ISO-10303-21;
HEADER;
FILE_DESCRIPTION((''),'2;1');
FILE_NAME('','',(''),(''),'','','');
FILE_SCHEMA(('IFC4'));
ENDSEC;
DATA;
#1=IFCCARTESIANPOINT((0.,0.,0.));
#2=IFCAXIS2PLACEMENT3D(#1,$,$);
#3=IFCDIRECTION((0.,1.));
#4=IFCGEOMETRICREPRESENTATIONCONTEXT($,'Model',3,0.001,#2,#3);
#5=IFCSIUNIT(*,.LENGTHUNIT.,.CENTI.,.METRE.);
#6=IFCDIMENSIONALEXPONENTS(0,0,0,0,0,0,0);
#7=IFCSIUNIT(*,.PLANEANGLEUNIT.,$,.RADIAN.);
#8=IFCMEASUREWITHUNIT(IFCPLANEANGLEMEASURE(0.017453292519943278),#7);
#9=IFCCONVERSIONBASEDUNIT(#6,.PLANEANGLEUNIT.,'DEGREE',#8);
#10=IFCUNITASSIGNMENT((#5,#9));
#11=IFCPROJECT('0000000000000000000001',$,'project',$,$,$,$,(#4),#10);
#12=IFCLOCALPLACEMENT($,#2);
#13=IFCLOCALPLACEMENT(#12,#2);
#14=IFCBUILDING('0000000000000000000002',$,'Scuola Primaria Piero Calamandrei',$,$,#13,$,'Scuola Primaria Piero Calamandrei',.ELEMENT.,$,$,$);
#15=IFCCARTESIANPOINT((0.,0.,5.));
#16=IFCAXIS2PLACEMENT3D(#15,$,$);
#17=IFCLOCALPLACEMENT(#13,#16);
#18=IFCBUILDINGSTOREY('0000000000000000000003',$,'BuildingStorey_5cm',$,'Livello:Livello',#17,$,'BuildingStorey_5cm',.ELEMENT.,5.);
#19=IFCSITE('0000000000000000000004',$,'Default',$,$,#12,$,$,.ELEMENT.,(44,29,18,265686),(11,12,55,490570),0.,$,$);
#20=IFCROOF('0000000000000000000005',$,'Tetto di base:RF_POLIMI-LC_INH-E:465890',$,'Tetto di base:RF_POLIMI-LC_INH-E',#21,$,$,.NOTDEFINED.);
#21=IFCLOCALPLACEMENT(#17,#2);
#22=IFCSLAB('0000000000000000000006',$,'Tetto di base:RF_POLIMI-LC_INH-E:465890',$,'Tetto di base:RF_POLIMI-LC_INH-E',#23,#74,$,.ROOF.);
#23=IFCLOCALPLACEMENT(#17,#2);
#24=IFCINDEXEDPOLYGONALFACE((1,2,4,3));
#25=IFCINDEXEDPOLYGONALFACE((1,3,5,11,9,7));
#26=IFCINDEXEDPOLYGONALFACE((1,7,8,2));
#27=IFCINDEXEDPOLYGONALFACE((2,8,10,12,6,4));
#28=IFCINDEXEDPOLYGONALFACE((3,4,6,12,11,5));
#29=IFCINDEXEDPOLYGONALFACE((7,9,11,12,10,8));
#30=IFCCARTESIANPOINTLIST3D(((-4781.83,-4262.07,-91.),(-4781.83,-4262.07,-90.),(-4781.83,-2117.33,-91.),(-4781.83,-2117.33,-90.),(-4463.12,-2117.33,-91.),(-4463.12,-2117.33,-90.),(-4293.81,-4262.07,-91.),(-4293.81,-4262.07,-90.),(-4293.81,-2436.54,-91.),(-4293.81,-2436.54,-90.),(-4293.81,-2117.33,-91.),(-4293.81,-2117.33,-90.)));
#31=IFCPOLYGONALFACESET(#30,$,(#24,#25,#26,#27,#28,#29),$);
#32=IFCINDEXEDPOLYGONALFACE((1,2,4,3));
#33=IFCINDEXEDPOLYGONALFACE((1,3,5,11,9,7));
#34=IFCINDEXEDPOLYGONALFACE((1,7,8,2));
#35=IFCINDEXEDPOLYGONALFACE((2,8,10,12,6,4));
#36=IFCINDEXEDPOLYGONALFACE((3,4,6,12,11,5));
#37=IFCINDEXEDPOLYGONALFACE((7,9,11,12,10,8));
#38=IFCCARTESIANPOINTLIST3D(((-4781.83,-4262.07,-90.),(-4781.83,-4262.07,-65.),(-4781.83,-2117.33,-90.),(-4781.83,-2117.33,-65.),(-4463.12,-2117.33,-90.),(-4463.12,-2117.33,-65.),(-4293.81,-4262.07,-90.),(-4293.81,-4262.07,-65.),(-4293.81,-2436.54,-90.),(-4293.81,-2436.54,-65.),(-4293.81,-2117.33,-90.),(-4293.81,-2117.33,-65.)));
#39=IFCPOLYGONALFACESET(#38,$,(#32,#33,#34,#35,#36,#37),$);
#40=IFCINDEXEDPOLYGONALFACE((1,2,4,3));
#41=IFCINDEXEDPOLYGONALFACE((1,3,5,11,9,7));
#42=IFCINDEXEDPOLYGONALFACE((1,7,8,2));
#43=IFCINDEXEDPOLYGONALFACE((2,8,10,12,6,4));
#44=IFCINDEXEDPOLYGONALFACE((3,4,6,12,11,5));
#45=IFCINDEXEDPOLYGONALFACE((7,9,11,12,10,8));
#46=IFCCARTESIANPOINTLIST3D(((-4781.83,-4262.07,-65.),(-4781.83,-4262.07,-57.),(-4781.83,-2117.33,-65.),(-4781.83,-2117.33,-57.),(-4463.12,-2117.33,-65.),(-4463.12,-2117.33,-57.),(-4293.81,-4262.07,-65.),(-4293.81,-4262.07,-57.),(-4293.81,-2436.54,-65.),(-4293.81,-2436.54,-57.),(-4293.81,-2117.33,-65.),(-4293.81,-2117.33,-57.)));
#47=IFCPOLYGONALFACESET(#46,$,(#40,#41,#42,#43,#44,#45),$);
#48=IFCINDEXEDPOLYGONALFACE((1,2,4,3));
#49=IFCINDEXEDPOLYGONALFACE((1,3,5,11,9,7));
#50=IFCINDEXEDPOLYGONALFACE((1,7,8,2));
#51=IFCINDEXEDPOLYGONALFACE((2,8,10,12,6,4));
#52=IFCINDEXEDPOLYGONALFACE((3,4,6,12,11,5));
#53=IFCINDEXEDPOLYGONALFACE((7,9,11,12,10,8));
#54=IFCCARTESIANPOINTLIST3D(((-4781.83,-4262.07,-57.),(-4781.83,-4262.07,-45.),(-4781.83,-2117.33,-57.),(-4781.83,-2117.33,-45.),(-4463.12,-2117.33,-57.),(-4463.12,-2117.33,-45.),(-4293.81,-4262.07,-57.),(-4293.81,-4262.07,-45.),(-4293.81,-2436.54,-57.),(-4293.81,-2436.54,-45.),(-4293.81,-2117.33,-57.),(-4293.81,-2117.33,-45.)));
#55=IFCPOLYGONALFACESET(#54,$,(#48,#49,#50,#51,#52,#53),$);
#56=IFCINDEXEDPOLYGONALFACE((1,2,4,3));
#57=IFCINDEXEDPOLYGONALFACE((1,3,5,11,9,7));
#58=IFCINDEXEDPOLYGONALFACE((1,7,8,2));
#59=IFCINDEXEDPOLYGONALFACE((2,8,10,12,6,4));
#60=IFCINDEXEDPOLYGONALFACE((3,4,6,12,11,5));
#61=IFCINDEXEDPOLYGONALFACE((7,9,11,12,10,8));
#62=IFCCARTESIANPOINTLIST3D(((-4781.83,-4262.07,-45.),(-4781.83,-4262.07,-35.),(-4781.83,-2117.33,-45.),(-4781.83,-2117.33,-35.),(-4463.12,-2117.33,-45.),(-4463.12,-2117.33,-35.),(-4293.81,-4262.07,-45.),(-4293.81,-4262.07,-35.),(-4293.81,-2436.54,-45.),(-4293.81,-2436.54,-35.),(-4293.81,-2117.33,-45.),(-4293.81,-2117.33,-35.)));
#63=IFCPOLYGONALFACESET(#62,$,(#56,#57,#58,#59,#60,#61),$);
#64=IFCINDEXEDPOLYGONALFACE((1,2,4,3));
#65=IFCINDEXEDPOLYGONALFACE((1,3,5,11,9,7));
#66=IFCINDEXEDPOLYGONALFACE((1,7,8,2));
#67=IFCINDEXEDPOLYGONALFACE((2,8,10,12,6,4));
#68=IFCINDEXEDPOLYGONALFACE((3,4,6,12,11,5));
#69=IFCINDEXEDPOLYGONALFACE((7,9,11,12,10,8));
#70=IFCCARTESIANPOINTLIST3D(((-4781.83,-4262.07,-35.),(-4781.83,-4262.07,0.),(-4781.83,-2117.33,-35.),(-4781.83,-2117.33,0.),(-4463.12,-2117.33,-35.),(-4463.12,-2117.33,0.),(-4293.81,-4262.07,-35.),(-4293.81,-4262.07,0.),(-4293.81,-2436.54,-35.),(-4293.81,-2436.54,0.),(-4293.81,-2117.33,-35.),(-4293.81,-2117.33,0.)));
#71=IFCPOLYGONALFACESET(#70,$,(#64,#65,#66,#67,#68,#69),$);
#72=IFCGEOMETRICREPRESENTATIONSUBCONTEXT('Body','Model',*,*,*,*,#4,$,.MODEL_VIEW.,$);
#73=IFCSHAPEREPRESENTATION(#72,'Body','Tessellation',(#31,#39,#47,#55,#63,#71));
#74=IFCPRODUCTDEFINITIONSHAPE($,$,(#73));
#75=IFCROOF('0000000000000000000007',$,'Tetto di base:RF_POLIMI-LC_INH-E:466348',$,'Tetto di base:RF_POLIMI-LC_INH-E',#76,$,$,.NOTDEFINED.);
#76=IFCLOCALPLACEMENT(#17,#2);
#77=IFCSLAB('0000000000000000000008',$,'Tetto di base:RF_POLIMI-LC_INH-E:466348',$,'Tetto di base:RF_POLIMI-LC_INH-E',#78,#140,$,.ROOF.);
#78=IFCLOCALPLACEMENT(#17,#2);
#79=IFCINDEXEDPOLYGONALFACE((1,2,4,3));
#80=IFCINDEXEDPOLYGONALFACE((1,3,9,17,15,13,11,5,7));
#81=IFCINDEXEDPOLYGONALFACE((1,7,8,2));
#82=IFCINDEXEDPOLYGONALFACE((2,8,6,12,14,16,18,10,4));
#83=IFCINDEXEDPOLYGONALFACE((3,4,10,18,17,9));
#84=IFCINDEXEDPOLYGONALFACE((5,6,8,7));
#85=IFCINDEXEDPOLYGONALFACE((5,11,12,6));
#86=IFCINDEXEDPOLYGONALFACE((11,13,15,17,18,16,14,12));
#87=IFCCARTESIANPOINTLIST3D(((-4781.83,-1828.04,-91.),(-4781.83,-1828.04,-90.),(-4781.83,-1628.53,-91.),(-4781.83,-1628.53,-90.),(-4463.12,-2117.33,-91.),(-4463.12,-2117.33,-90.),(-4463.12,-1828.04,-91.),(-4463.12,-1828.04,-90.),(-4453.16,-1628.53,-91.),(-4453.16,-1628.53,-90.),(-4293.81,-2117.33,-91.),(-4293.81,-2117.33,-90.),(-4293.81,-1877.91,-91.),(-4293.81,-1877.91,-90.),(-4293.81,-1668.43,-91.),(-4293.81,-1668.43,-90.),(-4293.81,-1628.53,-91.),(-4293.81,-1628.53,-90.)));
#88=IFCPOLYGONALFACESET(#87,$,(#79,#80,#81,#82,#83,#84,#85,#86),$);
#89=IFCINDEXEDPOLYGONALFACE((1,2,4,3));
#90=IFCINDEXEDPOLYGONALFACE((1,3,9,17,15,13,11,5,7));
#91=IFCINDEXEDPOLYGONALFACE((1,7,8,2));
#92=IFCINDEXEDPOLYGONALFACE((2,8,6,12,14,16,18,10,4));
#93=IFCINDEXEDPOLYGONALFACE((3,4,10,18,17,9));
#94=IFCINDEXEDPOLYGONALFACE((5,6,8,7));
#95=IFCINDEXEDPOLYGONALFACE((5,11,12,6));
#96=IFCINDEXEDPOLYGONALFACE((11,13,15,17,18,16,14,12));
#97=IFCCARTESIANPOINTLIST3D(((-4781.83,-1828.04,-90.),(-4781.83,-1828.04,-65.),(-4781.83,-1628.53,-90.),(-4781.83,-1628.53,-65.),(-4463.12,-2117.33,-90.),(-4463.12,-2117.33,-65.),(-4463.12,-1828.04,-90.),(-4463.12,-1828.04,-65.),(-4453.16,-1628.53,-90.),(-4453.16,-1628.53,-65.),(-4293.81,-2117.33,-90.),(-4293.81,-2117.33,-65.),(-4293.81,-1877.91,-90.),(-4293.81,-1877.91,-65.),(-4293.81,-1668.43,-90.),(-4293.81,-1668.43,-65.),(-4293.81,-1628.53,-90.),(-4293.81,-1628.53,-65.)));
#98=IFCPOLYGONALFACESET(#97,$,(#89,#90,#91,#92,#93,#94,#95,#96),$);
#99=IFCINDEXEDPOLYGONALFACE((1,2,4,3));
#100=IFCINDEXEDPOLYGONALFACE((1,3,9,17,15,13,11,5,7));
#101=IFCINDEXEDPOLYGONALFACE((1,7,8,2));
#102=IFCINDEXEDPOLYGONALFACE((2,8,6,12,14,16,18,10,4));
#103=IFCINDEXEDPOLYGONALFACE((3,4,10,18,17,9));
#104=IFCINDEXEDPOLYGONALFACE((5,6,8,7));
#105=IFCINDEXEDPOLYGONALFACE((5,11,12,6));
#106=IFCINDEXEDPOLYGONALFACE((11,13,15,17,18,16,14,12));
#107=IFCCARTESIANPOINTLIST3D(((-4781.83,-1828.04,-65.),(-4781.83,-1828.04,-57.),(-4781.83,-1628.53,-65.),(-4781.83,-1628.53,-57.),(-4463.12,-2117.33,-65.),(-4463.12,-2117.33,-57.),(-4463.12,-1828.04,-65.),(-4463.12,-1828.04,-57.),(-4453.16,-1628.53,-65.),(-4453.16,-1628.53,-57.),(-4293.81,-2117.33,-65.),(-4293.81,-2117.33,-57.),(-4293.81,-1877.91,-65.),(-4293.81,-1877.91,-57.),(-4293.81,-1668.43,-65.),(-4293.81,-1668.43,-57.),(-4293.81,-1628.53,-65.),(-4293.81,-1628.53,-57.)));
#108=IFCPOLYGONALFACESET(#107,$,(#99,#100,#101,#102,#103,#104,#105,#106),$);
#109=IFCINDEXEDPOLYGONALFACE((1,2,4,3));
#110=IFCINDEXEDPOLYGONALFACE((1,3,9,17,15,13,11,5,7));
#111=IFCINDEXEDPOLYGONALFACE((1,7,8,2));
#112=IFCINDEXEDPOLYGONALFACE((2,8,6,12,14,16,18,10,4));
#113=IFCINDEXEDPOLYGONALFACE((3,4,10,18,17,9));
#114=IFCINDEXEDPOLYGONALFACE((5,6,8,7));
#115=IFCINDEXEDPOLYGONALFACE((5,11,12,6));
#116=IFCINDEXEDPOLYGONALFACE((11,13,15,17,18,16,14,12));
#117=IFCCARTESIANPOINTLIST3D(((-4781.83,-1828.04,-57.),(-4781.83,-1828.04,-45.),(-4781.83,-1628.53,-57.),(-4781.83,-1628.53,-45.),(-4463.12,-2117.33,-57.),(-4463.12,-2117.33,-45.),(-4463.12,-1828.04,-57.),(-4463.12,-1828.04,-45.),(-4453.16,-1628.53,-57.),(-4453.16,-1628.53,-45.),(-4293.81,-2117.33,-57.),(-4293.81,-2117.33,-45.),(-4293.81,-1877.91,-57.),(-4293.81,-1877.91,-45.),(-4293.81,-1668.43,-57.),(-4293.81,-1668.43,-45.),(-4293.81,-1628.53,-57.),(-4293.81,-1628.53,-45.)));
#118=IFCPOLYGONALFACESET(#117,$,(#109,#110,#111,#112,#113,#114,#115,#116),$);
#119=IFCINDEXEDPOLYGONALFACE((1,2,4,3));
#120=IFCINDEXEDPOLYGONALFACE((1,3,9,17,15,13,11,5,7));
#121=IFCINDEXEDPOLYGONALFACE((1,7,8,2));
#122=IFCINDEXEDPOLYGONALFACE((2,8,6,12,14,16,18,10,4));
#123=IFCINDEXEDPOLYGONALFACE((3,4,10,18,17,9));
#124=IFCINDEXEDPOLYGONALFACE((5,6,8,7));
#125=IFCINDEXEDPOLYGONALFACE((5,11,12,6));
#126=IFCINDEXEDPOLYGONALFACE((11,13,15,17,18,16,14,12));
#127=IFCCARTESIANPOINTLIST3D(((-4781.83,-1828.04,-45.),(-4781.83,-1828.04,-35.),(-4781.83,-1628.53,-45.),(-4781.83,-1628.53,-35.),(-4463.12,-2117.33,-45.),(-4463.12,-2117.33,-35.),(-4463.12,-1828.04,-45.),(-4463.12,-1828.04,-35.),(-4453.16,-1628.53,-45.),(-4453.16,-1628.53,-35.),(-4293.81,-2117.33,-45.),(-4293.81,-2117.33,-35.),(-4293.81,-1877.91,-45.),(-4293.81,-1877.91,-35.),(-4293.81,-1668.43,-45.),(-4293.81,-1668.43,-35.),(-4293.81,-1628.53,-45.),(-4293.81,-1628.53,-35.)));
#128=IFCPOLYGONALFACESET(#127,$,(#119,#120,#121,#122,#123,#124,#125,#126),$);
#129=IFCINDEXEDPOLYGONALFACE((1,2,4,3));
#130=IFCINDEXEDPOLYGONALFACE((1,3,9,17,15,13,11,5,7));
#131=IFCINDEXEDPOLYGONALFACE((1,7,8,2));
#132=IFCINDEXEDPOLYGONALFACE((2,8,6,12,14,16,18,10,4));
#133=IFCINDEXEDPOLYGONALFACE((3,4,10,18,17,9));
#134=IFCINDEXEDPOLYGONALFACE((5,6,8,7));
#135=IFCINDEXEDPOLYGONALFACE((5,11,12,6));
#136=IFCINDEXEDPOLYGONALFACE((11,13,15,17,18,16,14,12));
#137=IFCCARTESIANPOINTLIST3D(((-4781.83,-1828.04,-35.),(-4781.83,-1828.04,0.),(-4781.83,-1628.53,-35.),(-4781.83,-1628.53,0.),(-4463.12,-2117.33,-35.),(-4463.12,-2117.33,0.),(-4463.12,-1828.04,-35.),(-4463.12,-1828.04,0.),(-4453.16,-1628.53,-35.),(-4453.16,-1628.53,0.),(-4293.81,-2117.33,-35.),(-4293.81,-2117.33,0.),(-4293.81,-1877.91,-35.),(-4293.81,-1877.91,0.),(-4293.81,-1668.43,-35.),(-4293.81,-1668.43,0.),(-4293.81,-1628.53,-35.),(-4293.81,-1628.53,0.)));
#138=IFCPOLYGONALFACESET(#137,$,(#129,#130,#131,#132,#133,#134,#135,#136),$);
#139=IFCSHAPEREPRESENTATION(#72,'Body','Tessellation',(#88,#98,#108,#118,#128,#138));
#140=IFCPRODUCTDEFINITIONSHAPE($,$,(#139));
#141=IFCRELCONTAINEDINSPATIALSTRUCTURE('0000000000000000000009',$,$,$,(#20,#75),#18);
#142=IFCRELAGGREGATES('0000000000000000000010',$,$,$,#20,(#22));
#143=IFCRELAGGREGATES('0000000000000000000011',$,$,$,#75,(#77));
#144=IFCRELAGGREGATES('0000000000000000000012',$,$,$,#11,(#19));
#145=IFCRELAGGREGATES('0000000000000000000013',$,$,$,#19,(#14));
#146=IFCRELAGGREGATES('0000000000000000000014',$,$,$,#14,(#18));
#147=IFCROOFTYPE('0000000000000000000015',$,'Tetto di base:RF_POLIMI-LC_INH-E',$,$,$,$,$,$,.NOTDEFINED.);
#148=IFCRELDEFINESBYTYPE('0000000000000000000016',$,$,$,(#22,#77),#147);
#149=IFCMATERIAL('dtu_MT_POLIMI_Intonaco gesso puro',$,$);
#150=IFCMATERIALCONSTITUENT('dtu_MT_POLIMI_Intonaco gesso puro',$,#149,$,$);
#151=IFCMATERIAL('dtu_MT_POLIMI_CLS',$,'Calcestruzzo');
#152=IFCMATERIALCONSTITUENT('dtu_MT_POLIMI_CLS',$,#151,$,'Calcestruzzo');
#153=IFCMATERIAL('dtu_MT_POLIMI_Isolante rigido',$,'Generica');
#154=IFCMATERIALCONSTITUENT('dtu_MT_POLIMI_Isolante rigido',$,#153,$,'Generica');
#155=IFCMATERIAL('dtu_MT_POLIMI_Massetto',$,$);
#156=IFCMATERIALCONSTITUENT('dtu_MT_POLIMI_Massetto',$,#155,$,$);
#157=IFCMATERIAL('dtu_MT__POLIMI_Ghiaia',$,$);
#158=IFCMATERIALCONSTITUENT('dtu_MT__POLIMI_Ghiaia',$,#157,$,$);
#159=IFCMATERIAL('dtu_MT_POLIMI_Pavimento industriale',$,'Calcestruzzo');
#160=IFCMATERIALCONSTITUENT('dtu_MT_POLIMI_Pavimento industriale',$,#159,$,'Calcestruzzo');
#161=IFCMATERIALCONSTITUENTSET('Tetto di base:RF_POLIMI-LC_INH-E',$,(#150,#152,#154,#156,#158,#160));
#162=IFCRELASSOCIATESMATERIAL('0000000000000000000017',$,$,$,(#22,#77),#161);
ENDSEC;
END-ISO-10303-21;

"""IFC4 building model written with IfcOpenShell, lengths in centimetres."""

from ifc_helpers import new_model, entity, si_unit, converted_unit, direction, frame, origin, place, context, subcontext, project, spatial, indexed_curve, outline, extrude, material, constituent, constituent_set, type_object, element, aggregate, save


model = new_model("IFC4")

# Units and contexts
model_context = context("Model", 3, precision=0.001, world=origin(), true_north=direction((0.0, 1.0)))
body_context = subcontext(model_context, "Body", "Model", "MODEL_VIEW")
ifc_project = project(units=[si_unit("LENGTHUNIT", "METRE", prefix="CENTI"), converted_unit("PLANEANGLEUNIT", "DEGREE", entity("IfcPlaneAngleMeasure", 0.017453292519943278), si_unit("PLANEANGLEUNIT", "RADIAN"), dimensions=[0, 0, 0, 0, 0, 0, 0])], contexts=[model_context])

# Site, building, storey
site_placement = place(None, origin())
site = spatial("IfcSite", under=ifc_project, at=site_placement, Name="Default", CompositionType="ELEMENT", RefLatitude=(44, 29, 18, 265686), RefLongitude=(11, 12, 55, 490570), RefElevation=0.0)
building_placement = place(site_placement, origin())
building = spatial("IfcBuilding", under=site, at=building_placement, Name="Scuola Primaria Piero Calamandrei", LongName="Scuola Primaria Piero Calamandrei", CompositionType="ELEMENT")
storey_placement = place(building_placement, frame((0.0, 0.0, 5.0)))
storey = spatial("IfcBuildingStorey", under=building, at=storey_placement, Name="BuildingStorey_5cm", ObjectType="Livello:Livello", LongName="BuildingStorey_5cm", CompositionType="ELEMENT", Elevation=5.0)

# Roofs, slabs
roof_1_placement = place(storey_placement, frame((-4781.83, -4262.07, -91.0)))
roof_1 = element("IfcRoof", 1, at=roof_1_placement, inside=storey, Name="Tetto di base:RF_POLIMI-LC_INH-E:465890", ObjectType="Tetto di base:RF_POLIMI-LC_INH-E", PredefinedType="NOTDEFINED")
ifc_material_1 = material(Name="dtu_MT_POLIMI_Intonaco gesso puro")
ifc_constituent_1 = constituent(ifc_material_1, Name="dtu_MT_POLIMI_Intonaco gesso puro")
ifc_material_2 = material(Name="dtu_MT_POLIMI_CLS", Category="Calcestruzzo")
ifc_constituent_2 = constituent(ifc_material_2, Name="dtu_MT_POLIMI_CLS", Category="Calcestruzzo")
ifc_material_3 = material(Name="dtu_MT_POLIMI_Isolante rigido", Category="Generica")
ifc_constituent_3 = constituent(ifc_material_3, Name="dtu_MT_POLIMI_Isolante rigido", Category="Generica")
ifc_material_4 = material(Name="dtu_MT_POLIMI_Massetto")
ifc_constituent_4 = constituent(ifc_material_4, Name="dtu_MT_POLIMI_Massetto")
ifc_material_5 = material(Name="dtu_MT__POLIMI_Ghiaia")
ifc_constituent_5 = constituent(ifc_material_5, Name="dtu_MT__POLIMI_Ghiaia")
ifc_material_6 = material(Name="dtu_MT_POLIMI_Pavimento industriale", Category="Calcestruzzo")
ifc_constituent_6 = constituent(ifc_material_6, Name="dtu_MT_POLIMI_Pavimento industriale", Category="Calcestruzzo")
ifc_constituent_set_1 = constituent_set(constituents=[ifc_constituent_1, ifc_constituent_2, ifc_constituent_3, ifc_constituent_4, ifc_constituent_5, ifc_constituent_6], Name="Tetto di base:RF_POLIMI-LC_INH-E")
roof_type = type_object("IfcRoofType", Name="Tetto di base:RF_POLIMI-LC_INH-E", PredefinedType="NOTDEFINED")
slab_1_placement = place(roof_1_placement, origin())
slab_1 = element("IfcSlab", 2, at=slab_1_placement, type_object=roof_type, material=ifc_constituent_set_1, Name="Tetto di base:RF_POLIMI-LC_INH-E:465890", ObjectType="Tetto di base:RF_POLIMI-LC_INH-E", PredefinedType="ROOF", context=body_context, shape_type="SweptSolid", body=[
    extrude(outline(indexed_curve([(74.7, 1072.37), (-244.01, 1072.37), (-244.01, -1072.37), (244.01, -1072.37), (244.01, 753.15), (244.01, 1072.37), (74.7, 1072.37)], self_intersect=False)), frame((244.01, 1072.37, 0.0)), (0.0, 0.0, 1.0), 1.0),
    extrude(outline(indexed_curve([(74.7, 1072.37), (-244.01, 1072.37), (-244.01, -1072.37), (244.01, -1072.37), (244.01, 753.15), (244.01, 1072.37), (74.7, 1072.37)], self_intersect=False)), frame((244.01, 1072.37, 1.0)), (0.0, 0.0, 1.0), 25.0),
    extrude(outline(indexed_curve([(74.7, 1072.37), (-244.01, 1072.37), (-244.01, -1072.37), (244.01, -1072.37), (244.01, 753.15), (244.01, 1072.37), (74.7, 1072.37)], self_intersect=False)), frame((244.01, 1072.37, 26.0)), (0.0, 0.0, 1.0), 8.0),
    extrude(outline(indexed_curve([(74.7, 1072.37), (-244.01, 1072.37), (-244.01, -1072.37), (244.01, -1072.37), (244.01, 753.15), (244.01, 1072.37), (74.7, 1072.37)], self_intersect=False)), frame((244.01, 1072.37, 34.0)), (0.0, 0.0, 1.0), 12.0),
    extrude(outline(indexed_curve([(74.7, 1072.37), (-244.01, 1072.37), (-244.01, -1072.37), (244.01, -1072.37), (244.01, 753.15), (244.01, 1072.37), (74.7, 1072.37)], self_intersect=False)), frame((244.01, 1072.37, 46.0)), (0.0, 0.0, 1.0), 10.0),
    extrude(outline(indexed_curve([(74.7, 1072.37), (-244.01, 1072.37), (-244.01, -1072.37), (244.01, -1072.37), (244.01, 753.15), (244.01, 1072.37), (74.7, 1072.37)], self_intersect=False)), frame((244.01, 1072.37, 56.0)), (0.0, 0.0, 1.0), 35.0),
])
aggregate(roof_1, [slab_1])
roof_2_placement = place(storey_placement, frame((-4781.83, -2117.33, -91.0)))
roof_2 = element("IfcRoof", 3, at=roof_2_placement, inside=storey, Name="Tetto di base:RF_POLIMI-LC_INH-E:466348", ObjectType="Tetto di base:RF_POLIMI-LC_INH-E", PredefinedType="NOTDEFINED")
slab_2_placement = place(roof_2_placement, origin())
slab_2 = element("IfcSlab", 4, at=slab_2_placement, type_object=roof_type, material=ifc_constituent_set_1, Name="Tetto di base:RF_POLIMI-LC_INH-E:466348", ObjectType="Tetto di base:RF_POLIMI-LC_INH-E", PredefinedType="ROOF", context=body_context, shape_type="SweptSolid", body=[
    extrude(outline(indexed_curve([(244.01, 244.4), (84.66, 244.4), (-244.01, 244.4), (-244.01, 44.89), (74.7, 44.89), (74.7, -244.4), (244.01, -244.4), (244.01, -4.99), (244.01, 204.5), (244.01, 244.4)], self_intersect=False)), frame((244.01, 244.4, 0.0)), (0.0, 0.0, 1.0), 1.0),
    extrude(outline(indexed_curve([(244.01, 244.4), (84.66, 244.4), (-244.01, 244.4), (-244.01, 44.89), (74.7, 44.89), (74.7, -244.4), (244.01, -244.4), (244.01, -4.99), (244.01, 204.5), (244.01, 244.4)], self_intersect=False)), frame((244.01, 244.4, 1.0)), (0.0, 0.0, 1.0), 25.0),
    extrude(outline(indexed_curve([(244.01, 244.4), (84.66, 244.4), (-244.01, 244.4), (-244.01, 44.89), (74.7, 44.89), (74.7, -244.4), (244.01, -244.4), (244.01, -4.99), (244.01, 204.5), (244.01, 244.4)], self_intersect=False)), frame((244.01, 244.4, 26.0)), (0.0, 0.0, 1.0), 8.0),
    extrude(outline(indexed_curve([(244.01, 244.4), (84.66, 244.4), (-244.01, 244.4), (-244.01, 44.89), (74.7, 44.89), (74.7, -244.4), (244.01, -244.4), (244.01, -4.99), (244.01, 204.5), (244.01, 244.4)], self_intersect=False)), frame((244.01, 244.4, 34.0)), (0.0, 0.0, 1.0), 12.0),
    extrude(outline(indexed_curve([(244.01, 244.4), (84.66, 244.4), (-244.01, 244.4), (-244.01, 44.89), (74.7, 44.89), (74.7, -244.4), (244.01, -244.4), (244.01, -4.99), (244.01, 204.5), (244.01, 244.4)], self_intersect=False)), frame((244.01, 244.4, 46.0)), (0.0, 0.0, 1.0), 10.0),
    extrude(outline(indexed_curve([(244.01, 244.4), (84.66, 244.4), (-244.01, 244.4), (-244.01, 44.89), (74.7, 44.89), (74.7, -244.4), (244.01, -244.4), (244.01, -4.99), (244.01, 204.5), (244.01, 244.4)], self_intersect=False)), frame((244.01, 244.4, 56.0)), (0.0, 0.0, 1.0), 35.0),
])
aggregate(roof_2, [slab_2])

save(model, "model.ifc")
